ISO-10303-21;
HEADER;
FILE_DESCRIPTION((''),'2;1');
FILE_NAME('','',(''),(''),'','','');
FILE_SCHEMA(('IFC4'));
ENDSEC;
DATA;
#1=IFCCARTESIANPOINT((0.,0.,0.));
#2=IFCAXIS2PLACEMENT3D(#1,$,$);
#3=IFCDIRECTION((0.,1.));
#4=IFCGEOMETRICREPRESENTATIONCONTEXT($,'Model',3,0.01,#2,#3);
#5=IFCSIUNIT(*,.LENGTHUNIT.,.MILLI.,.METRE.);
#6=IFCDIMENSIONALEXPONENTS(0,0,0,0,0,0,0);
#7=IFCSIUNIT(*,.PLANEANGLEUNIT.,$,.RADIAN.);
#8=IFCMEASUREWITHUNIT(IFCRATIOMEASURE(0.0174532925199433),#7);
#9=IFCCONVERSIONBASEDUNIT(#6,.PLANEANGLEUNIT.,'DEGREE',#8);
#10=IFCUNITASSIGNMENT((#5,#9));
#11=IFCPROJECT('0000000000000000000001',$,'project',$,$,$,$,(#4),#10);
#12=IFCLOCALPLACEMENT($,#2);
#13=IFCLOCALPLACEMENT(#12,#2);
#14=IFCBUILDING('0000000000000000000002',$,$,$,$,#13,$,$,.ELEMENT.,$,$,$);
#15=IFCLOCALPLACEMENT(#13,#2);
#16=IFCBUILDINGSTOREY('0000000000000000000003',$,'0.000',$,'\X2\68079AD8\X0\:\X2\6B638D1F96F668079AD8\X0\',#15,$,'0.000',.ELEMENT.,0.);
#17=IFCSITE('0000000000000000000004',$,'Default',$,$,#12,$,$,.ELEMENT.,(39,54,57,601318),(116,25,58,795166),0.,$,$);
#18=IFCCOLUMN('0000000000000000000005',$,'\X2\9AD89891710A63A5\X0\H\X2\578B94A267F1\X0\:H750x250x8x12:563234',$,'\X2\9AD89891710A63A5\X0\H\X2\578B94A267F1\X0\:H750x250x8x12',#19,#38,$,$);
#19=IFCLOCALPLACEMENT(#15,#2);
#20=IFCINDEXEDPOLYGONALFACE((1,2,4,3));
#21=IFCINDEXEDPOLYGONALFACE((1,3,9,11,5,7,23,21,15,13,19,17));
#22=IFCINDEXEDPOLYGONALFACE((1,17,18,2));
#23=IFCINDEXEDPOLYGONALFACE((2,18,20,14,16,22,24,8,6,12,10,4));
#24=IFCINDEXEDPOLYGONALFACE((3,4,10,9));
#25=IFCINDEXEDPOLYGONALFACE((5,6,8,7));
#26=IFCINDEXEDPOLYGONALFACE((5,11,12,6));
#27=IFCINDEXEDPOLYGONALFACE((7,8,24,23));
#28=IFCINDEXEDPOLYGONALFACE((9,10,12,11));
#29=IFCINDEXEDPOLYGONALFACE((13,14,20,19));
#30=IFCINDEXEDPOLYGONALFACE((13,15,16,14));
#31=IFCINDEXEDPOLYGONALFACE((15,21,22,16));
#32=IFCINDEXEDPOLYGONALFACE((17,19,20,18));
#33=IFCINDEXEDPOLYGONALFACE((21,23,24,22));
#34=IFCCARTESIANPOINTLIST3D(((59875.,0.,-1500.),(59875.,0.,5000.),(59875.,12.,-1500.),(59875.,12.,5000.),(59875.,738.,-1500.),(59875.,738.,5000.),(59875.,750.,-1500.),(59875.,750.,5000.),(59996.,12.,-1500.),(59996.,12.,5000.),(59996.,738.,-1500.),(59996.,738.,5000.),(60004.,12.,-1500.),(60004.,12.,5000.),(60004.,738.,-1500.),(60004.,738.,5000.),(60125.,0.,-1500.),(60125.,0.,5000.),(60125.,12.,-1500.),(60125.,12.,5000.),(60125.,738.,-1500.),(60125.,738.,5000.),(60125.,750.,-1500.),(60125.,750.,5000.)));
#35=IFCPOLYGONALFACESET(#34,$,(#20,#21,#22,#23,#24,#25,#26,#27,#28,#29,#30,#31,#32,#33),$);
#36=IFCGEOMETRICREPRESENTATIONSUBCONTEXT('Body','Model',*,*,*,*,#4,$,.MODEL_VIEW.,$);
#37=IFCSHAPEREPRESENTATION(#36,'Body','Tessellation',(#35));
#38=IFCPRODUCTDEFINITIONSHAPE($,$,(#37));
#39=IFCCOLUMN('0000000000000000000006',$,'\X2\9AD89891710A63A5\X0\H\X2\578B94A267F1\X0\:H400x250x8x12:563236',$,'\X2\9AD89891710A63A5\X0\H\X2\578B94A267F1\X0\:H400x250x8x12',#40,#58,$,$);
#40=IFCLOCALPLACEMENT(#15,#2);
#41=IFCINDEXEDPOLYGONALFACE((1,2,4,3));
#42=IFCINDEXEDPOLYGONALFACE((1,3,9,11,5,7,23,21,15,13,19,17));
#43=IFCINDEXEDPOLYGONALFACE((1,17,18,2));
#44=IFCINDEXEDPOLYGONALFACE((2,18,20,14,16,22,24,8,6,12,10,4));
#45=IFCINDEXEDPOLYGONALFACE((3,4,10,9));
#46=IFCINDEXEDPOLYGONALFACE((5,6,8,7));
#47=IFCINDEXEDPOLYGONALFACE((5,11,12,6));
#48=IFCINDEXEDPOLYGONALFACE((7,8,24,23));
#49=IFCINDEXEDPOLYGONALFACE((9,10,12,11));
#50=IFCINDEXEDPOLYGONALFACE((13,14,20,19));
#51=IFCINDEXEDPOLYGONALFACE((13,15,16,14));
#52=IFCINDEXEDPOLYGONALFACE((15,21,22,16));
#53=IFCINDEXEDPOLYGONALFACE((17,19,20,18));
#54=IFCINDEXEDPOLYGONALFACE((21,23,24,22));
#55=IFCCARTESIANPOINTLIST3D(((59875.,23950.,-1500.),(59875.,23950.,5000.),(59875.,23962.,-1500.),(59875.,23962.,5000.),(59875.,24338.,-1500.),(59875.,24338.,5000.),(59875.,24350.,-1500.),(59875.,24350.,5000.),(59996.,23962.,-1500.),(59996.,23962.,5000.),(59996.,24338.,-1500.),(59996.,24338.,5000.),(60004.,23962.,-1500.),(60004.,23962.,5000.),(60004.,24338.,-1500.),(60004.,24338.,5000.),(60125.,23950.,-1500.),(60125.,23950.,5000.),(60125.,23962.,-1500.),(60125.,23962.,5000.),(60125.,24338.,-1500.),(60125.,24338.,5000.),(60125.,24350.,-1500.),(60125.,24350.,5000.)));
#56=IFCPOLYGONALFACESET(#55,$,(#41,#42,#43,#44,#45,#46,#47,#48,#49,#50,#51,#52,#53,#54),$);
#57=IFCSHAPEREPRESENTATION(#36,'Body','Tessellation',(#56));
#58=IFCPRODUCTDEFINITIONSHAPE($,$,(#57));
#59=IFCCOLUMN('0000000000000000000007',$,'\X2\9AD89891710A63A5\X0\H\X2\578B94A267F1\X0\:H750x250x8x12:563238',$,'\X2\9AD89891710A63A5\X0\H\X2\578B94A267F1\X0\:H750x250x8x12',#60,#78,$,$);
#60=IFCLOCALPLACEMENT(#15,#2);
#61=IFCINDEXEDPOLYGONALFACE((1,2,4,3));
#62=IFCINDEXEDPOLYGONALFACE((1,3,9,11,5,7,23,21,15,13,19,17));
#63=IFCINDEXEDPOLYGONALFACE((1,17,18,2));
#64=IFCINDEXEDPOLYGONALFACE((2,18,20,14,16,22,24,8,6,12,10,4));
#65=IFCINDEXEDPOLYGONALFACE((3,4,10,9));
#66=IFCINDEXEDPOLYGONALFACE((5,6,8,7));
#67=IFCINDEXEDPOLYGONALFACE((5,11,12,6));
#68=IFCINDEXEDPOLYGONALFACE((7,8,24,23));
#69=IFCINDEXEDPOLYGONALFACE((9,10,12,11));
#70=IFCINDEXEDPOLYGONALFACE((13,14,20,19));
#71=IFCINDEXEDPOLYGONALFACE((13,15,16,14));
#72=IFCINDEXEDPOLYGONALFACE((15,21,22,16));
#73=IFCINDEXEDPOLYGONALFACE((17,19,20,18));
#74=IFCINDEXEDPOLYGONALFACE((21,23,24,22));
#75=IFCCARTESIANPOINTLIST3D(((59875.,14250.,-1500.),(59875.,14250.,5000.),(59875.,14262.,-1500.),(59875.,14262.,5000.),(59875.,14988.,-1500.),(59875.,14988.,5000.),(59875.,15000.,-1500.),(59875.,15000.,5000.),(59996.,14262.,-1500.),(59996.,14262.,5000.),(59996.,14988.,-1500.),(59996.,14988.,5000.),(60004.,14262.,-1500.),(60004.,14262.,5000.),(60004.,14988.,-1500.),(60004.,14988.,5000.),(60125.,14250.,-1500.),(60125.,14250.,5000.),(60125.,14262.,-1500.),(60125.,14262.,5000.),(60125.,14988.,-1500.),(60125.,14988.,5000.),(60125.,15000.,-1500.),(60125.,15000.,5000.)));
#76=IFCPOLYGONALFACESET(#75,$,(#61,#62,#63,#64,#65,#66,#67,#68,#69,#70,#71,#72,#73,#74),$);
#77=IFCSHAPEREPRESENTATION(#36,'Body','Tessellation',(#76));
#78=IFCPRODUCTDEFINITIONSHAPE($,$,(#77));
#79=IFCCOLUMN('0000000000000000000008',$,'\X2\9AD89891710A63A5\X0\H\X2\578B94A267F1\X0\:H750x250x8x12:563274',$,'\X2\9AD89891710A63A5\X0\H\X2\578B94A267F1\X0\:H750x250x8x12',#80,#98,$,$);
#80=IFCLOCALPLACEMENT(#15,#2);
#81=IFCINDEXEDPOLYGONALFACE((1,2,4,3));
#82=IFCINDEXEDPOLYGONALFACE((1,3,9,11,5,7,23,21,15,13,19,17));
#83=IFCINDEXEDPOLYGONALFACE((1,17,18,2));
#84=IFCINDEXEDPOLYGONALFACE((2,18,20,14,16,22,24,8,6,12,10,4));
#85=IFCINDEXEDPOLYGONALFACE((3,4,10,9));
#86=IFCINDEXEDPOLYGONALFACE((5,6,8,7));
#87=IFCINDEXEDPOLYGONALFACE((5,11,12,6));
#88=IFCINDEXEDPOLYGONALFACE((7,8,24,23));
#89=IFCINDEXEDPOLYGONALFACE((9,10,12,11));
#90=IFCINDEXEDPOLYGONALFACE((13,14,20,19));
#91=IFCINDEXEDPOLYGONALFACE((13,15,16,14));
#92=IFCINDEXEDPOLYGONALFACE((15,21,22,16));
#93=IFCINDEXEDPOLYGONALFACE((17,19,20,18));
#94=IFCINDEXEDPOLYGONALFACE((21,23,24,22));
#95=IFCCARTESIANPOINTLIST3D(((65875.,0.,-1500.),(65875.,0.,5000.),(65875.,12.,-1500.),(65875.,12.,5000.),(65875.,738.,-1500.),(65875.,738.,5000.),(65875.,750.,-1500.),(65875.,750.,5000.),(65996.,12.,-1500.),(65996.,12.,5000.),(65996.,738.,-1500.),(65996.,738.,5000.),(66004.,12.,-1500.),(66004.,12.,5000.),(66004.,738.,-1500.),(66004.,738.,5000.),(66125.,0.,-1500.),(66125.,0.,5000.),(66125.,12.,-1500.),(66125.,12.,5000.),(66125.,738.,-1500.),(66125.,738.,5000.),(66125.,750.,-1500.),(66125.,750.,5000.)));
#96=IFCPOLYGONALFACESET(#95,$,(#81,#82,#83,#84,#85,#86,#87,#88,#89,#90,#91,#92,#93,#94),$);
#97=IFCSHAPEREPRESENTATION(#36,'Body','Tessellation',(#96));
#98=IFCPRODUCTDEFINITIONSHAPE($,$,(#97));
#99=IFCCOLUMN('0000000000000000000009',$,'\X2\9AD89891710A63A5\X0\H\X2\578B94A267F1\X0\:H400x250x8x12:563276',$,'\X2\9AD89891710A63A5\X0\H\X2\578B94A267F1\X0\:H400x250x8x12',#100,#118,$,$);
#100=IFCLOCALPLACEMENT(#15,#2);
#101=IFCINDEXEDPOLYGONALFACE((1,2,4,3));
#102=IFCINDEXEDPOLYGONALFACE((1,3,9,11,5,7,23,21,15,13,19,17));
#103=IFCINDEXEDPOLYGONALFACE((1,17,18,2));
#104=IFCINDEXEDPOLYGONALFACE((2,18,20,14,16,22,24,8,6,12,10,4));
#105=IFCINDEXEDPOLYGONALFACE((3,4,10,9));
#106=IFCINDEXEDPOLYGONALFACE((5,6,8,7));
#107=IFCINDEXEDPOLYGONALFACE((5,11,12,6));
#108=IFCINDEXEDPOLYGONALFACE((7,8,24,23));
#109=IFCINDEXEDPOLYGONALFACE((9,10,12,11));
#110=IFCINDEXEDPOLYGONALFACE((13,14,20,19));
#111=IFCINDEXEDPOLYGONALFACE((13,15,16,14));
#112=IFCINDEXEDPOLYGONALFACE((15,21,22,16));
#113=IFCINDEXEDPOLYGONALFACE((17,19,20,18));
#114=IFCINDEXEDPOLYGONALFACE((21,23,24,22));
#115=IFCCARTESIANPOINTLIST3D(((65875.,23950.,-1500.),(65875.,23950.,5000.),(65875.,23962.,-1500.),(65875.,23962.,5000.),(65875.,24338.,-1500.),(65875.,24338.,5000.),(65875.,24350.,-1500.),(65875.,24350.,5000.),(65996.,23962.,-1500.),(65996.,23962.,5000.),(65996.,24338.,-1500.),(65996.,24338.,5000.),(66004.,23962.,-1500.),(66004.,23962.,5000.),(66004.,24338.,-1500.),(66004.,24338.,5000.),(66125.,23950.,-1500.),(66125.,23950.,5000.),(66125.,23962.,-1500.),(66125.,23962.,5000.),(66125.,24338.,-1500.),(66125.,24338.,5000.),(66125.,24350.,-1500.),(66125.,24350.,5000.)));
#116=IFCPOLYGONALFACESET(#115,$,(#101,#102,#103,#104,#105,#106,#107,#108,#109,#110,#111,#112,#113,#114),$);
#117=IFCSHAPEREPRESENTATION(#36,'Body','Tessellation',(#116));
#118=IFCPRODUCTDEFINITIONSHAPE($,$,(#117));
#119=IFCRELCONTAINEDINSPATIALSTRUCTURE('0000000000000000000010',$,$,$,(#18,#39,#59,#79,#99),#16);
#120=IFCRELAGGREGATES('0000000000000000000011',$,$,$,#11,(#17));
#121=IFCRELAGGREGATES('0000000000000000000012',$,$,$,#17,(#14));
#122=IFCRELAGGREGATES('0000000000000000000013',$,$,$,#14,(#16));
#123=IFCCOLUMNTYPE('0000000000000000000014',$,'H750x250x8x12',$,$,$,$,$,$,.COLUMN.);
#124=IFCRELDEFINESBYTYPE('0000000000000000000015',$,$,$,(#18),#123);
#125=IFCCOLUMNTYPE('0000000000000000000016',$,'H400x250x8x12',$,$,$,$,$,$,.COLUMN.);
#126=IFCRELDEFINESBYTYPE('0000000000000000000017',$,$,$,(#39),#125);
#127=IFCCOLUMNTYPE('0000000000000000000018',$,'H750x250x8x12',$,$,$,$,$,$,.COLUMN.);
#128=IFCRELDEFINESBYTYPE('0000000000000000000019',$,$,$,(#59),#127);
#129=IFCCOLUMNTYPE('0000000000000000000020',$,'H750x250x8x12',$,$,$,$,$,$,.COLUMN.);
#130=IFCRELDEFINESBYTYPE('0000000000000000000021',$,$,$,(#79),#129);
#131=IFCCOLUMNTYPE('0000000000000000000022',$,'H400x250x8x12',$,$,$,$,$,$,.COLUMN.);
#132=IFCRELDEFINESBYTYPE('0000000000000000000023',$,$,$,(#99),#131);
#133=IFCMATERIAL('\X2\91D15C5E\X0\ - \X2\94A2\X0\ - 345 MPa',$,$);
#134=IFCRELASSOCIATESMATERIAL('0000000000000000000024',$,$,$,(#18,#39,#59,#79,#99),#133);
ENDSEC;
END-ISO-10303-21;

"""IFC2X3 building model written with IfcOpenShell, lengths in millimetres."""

from ifc_helpers import new_model, entity, si_unit, converted_unit, direction, frame, origin, place, context, subcontext, project, spatial, polyline, outline, extrude, source, transform, mapped, material, type_object, type_shapes, element, save


model = new_model("IFC2X3")

# Units and contexts
model_context = context("Model", 3, precision=0.01, world=origin(), true_north=direction((0.0, 1.0)))
body_context = subcontext(model_context, "Body", "Model", "MODEL_VIEW")
ifc_project = project(units=[si_unit("LENGTHUNIT", "METRE", prefix="MILLI"), converted_unit("PLANEANGLEUNIT", "DEGREE", entity("IfcRatioMeasure", 0.0174532925199433), si_unit("PLANEANGLEUNIT", "RADIAN"), dimensions=[0, 0, 0, 0, 0, 0, 0])], contexts=[model_context])

# Site, building, storey
site_placement = place(None, origin())
site = spatial("IfcSite", under=ifc_project, at=site_placement, Name="Default", CompositionType="ELEMENT", RefLatitude=(39, 54, 57, 601318), RefLongitude=(116, 25, 58, 795166), RefElevation=0.0)
building_placement = place(site_placement, origin())
building = spatial("IfcBuilding", under=site, at=building_placement, CompositionType="ELEMENT")
storey_placement = place(building_placement, origin())
storey = spatial("IfcBuildingStorey", under=building, at=storey_placement, Name="0.000", ObjectType="标高:正负零标高", LongName="0.000", CompositionType="ELEMENT", Elevation=0.0)

# Columns
ifc_material_1 = material(Name="金属 - 钢 - 345 MPa")
column_type_1 = type_object("IfcColumnType", Name="H750x250x8x12", PredefinedType="COLUMN")
shared_shape_1 = source(origin(), body_context, "Body", "SweptSolid", [
    extrude(outline(polyline([(363.0, -125.0), (375.0, -125.0), (375.0, 125.0), (363.0, 125.0), (363.0, 4.0), (-363.0, 4.0), (-363.0, 125.0), (-375.0, 125.0), (-375.0, -125.0), (-363.0, -125.0), (-363.0, -4.0), (363.0, -4.0), (363.0, -125.0)])), frame((60000.0, 375.0, -1500.0), z_axis=(0.0, 0.0, 1.0), x_axis=(0.0, -1.0, 0.0)), (0.0, 0.0, 1.0), 6500.0),
])
type_shapes(column_type_1, [shared_shape_1])
column_1_placement = place(storey_placement, origin())
element("IfcColumn", 1, at=column_1_placement, inside=storey, type_object=column_type_1, material=ifc_material_1, Name="高频焊接H型钢柱:H750x250x8x12:563234", ObjectType="高频焊接H型钢柱:H750x250x8x12", context=body_context, shape_type="MappedRepresentation", body=[
    mapped(shared_shape_1, transform((0.0, 0.0, 0.0), scale=1.0)),
])
column_type_2 = type_object("IfcColumnType", Name="H400x250x8x12", PredefinedType="COLUMN")
shared_shape_2 = source(origin(), body_context, "Body", "SweptSolid", [
    extrude(outline(polyline([(188.0, -125.0), (200.0, -125.0), (200.0, 125.0), (188.0, 125.0), (188.0, 4.0), (-188.0, 4.0), (-188.0, 125.0), (-200.0, 125.0), (-200.0, -125.0), (-188.0, -125.0), (-188.0, -4.0), (188.0, -4.0), (188.0, -125.0)])), frame((60000.0, 24150.0, -1500.0), z_axis=(0.0, 0.0, 1.0), x_axis=(0.0, -1.0, 0.0)), (0.0, 0.0, 1.0), 6500.0),
])
type_shapes(column_type_2, [shared_shape_2])
column_2_placement = place(storey_placement, origin())
element("IfcColumn", 2, at=column_2_placement, inside=storey, type_object=column_type_2, material=ifc_material_1, Name="高频焊接H型钢柱:H400x250x8x12:563236", ObjectType="高频焊接H型钢柱:H400x250x8x12", context=body_context, shape_type="MappedRepresentation", body=[
    mapped(shared_shape_2, transform((0.0, 0.0, 0.0), scale=1.0)),
])
column_type_3 = type_object("IfcColumnType", Name="H750x250x8x12", PredefinedType="COLUMN")
shared_shape_3 = source(origin(), body_context, "Body", "SweptSolid", [
    extrude(outline(polyline([(363.0, -125.0), (375.0, -125.0), (375.0, 125.0), (363.0, 125.0), (363.0, 4.0), (-363.0, 4.0), (-363.0, 125.0), (-375.0, 125.0), (-375.0, -125.0), (-363.0, -125.0), (-363.0, -4.0), (363.0, -4.0), (363.0, -125.0)])), frame((60000.0, 14625.0, -1500.0), z_axis=(0.0, 0.0, 1.0), x_axis=(0.0, -1.0, 0.0)), (0.0, 0.0, 1.0), 6500.0),
])
type_shapes(column_type_3, [shared_shape_3])
column_3_placement = place(storey_placement, origin())
element("IfcColumn", 3, at=column_3_placement, inside=storey, type_object=column_type_3, material=ifc_material_1, Name="高频焊接H型钢柱:H750x250x8x12:563238", ObjectType="高频焊接H型钢柱:H750x250x8x12", context=body_context, shape_type="MappedRepresentation", body=[
    mapped(shared_shape_3, transform((0.0, 0.0, 0.0), scale=1.0)),
])
column_type_4 = type_object("IfcColumnType", Name="H750x250x8x12", PredefinedType="COLUMN")
shared_shape_4 = source(origin(), body_context, "Body", "SweptSolid", [
    extrude(outline(polyline([(363.0, -125.0), (375.0, -125.0), (375.0, 125.0), (363.0, 125.0), (363.0, 4.0), (-363.0, 4.0), (-363.0, 125.0), (-375.0, 125.0), (-375.0, -125.0), (-363.0, -125.0), (-363.0, -4.0), (363.0, -4.0), (363.0, -125.0)])), frame((66000.0, 375.0, -1500.0), z_axis=(0.0, 0.0, 1.0), x_axis=(0.0, -1.0, 0.0)), (0.0, 0.0, 1.0), 6500.0),
])
type_shapes(column_type_4, [shared_shape_4])
column_4_placement = place(storey_placement, origin())
element("IfcColumn", 4, at=column_4_placement, inside=storey, type_object=column_type_4, material=ifc_material_1, Name="高频焊接H型钢柱:H750x250x8x12:563274", ObjectType="高频焊接H型钢柱:H750x250x8x12", context=body_context, shape_type="MappedRepresentation", body=[
    mapped(shared_shape_4, transform((0.0, 0.0, 0.0), scale=1.0)),
])
column_type_5 = type_object("IfcColumnType", Name="H400x250x8x12", PredefinedType="COLUMN")
shared_shape_5 = source(origin(), body_context, "Body", "SweptSolid", [
    extrude(outline(polyline([(188.0, -125.0), (200.0, -125.0), (200.0, 125.0), (188.0, 125.0), (188.0, 4.0), (-188.0, 4.0), (-188.0, 125.0), (-200.0, 125.0), (-200.0, -125.0), (-188.0, -125.0), (-188.0, -4.0), (188.0, -4.0), (188.0, -125.0)])), frame((66000.0, 24150.0, -1500.0), z_axis=(0.0, 0.0, 1.0), x_axis=(0.0, -1.0, 0.0)), (0.0, 0.0, 1.0), 6500.0),
])
type_shapes(column_type_5, [shared_shape_5])
column_5_placement = place(storey_placement, origin())
element("IfcColumn", 5, at=column_5_placement, inside=storey, type_object=column_type_5, material=ifc_material_1, Name="高频焊接H型钢柱:H400x250x8x12:563276", ObjectType="高频焊接H型钢柱:H400x250x8x12", context=body_context, shape_type="MappedRepresentation", body=[
    mapped(shared_shape_5, transform((0.0, 0.0, 0.0), scale=1.0)),
])

save(model, "model.ifc")
